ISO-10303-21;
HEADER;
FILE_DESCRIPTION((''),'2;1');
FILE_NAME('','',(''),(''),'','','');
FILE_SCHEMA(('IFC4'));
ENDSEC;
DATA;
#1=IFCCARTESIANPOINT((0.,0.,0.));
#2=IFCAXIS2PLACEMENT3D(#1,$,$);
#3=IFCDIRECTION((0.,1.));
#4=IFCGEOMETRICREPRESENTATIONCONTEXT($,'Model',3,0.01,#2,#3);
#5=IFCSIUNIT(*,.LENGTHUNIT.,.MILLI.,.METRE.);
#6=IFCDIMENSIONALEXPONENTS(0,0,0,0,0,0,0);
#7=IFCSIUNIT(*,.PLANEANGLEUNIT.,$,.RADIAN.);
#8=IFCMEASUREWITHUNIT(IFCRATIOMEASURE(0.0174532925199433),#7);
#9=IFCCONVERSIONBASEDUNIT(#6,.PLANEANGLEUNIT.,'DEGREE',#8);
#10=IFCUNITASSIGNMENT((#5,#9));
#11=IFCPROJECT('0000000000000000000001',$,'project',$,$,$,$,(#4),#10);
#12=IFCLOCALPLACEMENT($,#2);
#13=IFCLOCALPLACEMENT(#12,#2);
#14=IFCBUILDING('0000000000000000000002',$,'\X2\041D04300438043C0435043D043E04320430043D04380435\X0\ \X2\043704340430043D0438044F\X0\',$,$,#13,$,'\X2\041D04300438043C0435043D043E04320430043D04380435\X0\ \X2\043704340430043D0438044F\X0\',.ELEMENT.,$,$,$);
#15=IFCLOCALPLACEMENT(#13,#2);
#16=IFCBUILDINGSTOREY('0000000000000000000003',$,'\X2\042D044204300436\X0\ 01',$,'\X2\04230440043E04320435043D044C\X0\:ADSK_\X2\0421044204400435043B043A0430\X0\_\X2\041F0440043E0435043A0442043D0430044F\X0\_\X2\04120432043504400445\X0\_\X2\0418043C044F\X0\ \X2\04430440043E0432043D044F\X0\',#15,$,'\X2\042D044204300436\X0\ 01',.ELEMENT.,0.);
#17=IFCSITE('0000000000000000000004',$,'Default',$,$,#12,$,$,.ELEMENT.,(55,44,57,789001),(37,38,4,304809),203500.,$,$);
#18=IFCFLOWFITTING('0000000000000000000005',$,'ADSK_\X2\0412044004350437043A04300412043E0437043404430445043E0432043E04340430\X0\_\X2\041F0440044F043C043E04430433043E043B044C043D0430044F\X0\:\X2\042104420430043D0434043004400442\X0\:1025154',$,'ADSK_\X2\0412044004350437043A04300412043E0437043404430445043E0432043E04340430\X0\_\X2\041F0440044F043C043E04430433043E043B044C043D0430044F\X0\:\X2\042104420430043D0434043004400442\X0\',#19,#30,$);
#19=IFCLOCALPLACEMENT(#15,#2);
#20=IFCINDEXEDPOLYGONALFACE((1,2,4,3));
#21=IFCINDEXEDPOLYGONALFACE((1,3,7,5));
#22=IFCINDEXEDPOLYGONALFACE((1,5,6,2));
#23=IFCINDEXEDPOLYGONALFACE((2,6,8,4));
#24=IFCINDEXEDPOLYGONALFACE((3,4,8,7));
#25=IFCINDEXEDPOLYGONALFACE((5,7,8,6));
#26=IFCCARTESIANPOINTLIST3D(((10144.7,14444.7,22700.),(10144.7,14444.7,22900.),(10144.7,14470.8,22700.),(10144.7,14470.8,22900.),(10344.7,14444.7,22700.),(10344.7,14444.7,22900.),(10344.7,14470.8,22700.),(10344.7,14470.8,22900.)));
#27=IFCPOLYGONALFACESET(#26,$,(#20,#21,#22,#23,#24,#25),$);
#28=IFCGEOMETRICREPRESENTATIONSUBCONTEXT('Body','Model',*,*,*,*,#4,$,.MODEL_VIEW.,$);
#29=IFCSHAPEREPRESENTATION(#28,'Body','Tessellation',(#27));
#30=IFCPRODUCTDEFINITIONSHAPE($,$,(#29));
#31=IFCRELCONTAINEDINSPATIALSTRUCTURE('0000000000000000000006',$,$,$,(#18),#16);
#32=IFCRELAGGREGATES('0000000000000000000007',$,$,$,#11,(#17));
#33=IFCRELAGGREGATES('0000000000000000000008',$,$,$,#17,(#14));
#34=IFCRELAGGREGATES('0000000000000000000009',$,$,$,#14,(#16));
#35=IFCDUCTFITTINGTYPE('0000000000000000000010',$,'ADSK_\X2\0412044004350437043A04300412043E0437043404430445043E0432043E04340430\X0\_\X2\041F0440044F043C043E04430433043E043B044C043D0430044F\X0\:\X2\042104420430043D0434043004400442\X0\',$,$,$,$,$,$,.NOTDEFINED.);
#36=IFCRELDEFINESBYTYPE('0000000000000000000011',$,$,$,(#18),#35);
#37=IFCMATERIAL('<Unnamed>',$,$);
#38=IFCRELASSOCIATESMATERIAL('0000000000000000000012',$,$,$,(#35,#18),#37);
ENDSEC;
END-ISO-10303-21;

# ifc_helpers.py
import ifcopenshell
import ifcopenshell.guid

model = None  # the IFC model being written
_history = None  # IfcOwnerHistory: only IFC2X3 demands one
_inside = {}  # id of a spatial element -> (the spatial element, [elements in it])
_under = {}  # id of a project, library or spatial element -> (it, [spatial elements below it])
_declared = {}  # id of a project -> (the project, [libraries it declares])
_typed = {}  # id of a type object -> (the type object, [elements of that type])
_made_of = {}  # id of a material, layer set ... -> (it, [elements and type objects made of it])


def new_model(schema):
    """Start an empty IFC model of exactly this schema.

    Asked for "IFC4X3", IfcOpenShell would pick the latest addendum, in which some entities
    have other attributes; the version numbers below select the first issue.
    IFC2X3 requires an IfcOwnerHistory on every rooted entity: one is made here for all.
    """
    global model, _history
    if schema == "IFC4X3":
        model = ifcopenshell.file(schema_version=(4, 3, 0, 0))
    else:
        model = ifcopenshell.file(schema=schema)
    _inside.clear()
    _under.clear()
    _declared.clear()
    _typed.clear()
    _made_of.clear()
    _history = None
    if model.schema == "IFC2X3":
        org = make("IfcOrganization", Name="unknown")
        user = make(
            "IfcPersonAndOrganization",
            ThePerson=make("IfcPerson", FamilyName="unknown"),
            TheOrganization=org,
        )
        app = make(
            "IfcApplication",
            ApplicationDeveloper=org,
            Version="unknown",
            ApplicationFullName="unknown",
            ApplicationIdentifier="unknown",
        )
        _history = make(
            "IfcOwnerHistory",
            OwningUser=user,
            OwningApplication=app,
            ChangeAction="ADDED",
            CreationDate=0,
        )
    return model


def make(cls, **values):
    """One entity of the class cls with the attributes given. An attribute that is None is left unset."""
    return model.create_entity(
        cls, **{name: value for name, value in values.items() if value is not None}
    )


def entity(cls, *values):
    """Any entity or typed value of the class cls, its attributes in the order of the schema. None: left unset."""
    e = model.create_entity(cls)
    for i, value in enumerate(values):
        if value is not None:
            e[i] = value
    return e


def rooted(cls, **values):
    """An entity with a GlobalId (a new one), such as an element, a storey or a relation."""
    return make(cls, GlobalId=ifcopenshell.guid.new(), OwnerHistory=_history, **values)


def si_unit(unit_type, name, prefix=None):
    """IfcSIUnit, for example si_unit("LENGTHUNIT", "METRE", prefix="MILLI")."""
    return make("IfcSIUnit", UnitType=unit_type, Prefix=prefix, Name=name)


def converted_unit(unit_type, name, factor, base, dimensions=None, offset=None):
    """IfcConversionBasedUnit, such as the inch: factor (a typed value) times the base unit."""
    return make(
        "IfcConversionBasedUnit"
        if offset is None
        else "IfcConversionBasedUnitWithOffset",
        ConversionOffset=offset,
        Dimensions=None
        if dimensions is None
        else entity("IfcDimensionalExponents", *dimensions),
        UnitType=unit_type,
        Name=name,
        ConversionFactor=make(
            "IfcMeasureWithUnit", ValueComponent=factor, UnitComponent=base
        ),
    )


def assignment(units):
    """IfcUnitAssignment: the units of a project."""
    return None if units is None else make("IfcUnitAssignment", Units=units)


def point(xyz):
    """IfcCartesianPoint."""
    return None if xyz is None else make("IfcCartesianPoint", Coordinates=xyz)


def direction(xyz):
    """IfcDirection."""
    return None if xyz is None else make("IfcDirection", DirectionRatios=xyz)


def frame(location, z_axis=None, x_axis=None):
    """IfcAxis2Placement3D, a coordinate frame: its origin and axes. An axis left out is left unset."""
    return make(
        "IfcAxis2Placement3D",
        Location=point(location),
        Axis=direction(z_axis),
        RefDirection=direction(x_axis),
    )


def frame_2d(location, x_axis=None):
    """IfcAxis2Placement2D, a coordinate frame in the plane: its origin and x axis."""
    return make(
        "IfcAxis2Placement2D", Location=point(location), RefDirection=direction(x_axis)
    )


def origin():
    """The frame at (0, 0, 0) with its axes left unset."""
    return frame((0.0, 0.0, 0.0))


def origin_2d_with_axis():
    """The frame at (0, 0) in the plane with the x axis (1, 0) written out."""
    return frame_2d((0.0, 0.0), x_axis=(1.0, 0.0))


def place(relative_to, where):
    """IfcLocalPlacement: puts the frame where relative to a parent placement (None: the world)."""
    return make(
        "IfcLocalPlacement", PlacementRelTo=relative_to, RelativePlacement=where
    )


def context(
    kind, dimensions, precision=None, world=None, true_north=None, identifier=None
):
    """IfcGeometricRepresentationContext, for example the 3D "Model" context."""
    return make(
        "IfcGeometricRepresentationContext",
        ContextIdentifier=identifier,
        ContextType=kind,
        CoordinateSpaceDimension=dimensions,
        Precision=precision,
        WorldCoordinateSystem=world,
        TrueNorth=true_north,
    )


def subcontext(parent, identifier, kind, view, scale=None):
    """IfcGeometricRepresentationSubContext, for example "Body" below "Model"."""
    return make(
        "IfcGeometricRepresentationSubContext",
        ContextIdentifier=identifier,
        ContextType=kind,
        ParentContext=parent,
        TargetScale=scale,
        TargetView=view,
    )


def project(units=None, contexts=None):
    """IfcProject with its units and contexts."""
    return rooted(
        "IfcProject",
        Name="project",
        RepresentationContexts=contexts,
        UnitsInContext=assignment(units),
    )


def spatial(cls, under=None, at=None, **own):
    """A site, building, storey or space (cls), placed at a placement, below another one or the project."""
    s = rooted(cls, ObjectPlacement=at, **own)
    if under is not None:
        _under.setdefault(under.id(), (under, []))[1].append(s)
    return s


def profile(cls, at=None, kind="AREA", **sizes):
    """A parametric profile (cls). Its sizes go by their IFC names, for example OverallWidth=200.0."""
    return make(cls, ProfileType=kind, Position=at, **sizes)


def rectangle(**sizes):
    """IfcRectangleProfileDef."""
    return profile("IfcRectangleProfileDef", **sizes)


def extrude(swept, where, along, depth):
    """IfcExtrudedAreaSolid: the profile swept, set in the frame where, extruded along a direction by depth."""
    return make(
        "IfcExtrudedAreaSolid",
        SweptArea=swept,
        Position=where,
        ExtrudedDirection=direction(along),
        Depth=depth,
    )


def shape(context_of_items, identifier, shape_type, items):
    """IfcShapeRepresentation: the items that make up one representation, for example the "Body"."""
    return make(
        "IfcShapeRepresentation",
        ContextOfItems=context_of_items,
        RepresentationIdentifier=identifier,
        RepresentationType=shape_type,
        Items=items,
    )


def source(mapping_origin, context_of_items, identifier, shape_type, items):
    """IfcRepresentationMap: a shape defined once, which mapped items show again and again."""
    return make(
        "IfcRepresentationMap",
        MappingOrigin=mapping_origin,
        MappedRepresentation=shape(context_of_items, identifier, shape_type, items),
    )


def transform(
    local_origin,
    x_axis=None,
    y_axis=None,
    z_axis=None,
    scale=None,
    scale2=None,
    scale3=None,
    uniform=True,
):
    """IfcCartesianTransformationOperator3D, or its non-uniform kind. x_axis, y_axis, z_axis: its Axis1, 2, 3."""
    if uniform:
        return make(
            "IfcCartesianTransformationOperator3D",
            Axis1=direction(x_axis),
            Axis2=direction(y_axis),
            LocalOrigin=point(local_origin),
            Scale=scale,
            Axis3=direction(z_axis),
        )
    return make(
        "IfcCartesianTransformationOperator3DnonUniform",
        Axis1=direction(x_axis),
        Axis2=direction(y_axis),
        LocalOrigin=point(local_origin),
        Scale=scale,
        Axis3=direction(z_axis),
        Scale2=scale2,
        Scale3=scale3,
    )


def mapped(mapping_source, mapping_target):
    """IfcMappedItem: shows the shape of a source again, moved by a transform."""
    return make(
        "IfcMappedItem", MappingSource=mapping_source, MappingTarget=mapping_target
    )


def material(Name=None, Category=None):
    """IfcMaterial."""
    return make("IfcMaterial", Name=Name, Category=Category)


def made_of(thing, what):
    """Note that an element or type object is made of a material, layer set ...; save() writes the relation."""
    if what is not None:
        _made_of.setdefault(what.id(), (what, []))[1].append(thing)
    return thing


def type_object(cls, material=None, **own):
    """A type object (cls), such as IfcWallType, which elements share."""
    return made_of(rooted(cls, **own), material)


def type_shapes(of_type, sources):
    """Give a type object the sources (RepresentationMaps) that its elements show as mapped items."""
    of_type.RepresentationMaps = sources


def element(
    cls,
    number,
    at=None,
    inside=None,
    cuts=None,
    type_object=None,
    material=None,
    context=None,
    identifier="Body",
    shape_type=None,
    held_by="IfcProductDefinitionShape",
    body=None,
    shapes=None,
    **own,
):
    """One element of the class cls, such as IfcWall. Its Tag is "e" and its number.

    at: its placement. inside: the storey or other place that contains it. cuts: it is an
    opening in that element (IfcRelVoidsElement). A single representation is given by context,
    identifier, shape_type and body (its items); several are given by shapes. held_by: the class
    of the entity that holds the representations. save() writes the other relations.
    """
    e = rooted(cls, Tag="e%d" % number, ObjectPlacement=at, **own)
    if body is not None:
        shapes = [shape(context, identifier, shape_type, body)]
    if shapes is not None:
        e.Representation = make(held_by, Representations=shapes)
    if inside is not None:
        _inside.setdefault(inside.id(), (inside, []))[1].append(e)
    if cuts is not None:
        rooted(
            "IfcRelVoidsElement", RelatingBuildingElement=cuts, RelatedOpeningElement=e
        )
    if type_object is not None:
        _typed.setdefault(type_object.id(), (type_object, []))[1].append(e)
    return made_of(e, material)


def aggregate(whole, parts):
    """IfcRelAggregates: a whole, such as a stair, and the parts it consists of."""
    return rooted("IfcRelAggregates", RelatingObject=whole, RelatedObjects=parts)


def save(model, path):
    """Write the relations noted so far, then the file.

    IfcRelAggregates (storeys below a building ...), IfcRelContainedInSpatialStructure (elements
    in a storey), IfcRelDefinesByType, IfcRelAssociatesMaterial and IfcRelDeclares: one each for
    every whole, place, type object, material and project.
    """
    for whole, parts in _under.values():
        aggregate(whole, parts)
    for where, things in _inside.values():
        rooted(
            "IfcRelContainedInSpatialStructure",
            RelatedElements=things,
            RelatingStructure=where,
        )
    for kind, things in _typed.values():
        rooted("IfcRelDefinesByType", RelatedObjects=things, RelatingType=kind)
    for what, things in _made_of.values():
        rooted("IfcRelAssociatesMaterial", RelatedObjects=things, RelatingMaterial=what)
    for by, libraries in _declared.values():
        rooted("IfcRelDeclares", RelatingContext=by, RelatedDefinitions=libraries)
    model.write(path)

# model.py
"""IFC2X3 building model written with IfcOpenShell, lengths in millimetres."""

from ifc_helpers import new_model, entity, si_unit, converted_unit, direction, frame, origin, origin_2d_with_axis, place, context, subcontext, project, spatial, rectangle, extrude, source, transform, mapped, material, type_object, type_shapes, element, save


model = new_model("IFC2X3")

# Units and contexts
model_context = context("Model", 3, precision=0.01, world=origin(), true_north=direction((0.0, 1.0)))
body_context = subcontext(model_context, "Body", "Model", "MODEL_VIEW")
ifc_project = project(units=[si_unit("LENGTHUNIT", "METRE", prefix="MILLI"), converted_unit("PLANEANGLEUNIT", "DEGREE", entity("IfcRatioMeasure", 0.0174532925199433), si_unit("PLANEANGLEUNIT", "RADIAN"), dimensions=[0, 0, 0, 0, 0, 0, 0])], contexts=[model_context])

# Site, building, storey
site_placement = place(None, origin())
site = spatial("IfcSite", under=ifc_project, at=site_placement, Name="Default", CompositionType="ELEMENT", RefLatitude=(55, 44, 57, 789001), RefLongitude=(37, 38, 4, 304809), RefElevation=203500.0)
building_placement = place(site_placement, origin())
building = spatial("IfcBuilding", under=site, at=building_placement, Name="Наименование здания", LongName="Наименование здания", CompositionType="ELEMENT")
storey_placement = place(building_placement, origin())
storey = spatial("IfcBuildingStorey", under=building, at=storey_placement, Name="Этаж 01", ObjectType="Уровень:ADSK_Стрелка_Проектная_Вверх_Имя уровня", LongName="Этаж 01", CompositionType="ELEMENT", Elevation=0.0)

# Flow fitting
ifc_material_1 = material(Name="<Unnamed>")
duct_fitting_type_1 = type_object("IfcDuctFittingType", Name="ADSK_ВрезкаВоздуховода_Прямоугольная:Стандарт", PredefinedType="NOTDEFINED", material=ifc_material_1)
shared_shape_1 = source(origin(), body_context, "Body", "SweptSolid", [
    extrude(rectangle(XDim=26.1, YDim=200.0, at=origin_2d_with_axis()), frame((7.0, 0.0, -100.0)), (0.0, 0.0, 1.0), 200.0),
])
type_shapes(duct_fitting_type_1, [shared_shape_1])
flow_fitting_1_placement = place(storey_placement, frame((10244.7, 14450.8, 22800.0), z_axis=(1.0, 0.0, 0.0), x_axis=(0.0, 1.0, 0.0)))
element("IfcFlowFitting", 1, at=flow_fitting_1_placement, inside=storey, type_object=duct_fitting_type_1, material=ifc_material_1, Name="ADSK_ВрезкаВоздуховода_Прямоугольная:Стандарт:1025154", ObjectType="ADSK_ВрезкаВоздуховода_Прямоугольная:Стандарт", context=body_context, shape_type="MappedRepresentation", body=[
    mapped(shared_shape_1, transform((0.0, 0.0, 0.0), scale=1.0)),
])

save(model, "model.ifc")
